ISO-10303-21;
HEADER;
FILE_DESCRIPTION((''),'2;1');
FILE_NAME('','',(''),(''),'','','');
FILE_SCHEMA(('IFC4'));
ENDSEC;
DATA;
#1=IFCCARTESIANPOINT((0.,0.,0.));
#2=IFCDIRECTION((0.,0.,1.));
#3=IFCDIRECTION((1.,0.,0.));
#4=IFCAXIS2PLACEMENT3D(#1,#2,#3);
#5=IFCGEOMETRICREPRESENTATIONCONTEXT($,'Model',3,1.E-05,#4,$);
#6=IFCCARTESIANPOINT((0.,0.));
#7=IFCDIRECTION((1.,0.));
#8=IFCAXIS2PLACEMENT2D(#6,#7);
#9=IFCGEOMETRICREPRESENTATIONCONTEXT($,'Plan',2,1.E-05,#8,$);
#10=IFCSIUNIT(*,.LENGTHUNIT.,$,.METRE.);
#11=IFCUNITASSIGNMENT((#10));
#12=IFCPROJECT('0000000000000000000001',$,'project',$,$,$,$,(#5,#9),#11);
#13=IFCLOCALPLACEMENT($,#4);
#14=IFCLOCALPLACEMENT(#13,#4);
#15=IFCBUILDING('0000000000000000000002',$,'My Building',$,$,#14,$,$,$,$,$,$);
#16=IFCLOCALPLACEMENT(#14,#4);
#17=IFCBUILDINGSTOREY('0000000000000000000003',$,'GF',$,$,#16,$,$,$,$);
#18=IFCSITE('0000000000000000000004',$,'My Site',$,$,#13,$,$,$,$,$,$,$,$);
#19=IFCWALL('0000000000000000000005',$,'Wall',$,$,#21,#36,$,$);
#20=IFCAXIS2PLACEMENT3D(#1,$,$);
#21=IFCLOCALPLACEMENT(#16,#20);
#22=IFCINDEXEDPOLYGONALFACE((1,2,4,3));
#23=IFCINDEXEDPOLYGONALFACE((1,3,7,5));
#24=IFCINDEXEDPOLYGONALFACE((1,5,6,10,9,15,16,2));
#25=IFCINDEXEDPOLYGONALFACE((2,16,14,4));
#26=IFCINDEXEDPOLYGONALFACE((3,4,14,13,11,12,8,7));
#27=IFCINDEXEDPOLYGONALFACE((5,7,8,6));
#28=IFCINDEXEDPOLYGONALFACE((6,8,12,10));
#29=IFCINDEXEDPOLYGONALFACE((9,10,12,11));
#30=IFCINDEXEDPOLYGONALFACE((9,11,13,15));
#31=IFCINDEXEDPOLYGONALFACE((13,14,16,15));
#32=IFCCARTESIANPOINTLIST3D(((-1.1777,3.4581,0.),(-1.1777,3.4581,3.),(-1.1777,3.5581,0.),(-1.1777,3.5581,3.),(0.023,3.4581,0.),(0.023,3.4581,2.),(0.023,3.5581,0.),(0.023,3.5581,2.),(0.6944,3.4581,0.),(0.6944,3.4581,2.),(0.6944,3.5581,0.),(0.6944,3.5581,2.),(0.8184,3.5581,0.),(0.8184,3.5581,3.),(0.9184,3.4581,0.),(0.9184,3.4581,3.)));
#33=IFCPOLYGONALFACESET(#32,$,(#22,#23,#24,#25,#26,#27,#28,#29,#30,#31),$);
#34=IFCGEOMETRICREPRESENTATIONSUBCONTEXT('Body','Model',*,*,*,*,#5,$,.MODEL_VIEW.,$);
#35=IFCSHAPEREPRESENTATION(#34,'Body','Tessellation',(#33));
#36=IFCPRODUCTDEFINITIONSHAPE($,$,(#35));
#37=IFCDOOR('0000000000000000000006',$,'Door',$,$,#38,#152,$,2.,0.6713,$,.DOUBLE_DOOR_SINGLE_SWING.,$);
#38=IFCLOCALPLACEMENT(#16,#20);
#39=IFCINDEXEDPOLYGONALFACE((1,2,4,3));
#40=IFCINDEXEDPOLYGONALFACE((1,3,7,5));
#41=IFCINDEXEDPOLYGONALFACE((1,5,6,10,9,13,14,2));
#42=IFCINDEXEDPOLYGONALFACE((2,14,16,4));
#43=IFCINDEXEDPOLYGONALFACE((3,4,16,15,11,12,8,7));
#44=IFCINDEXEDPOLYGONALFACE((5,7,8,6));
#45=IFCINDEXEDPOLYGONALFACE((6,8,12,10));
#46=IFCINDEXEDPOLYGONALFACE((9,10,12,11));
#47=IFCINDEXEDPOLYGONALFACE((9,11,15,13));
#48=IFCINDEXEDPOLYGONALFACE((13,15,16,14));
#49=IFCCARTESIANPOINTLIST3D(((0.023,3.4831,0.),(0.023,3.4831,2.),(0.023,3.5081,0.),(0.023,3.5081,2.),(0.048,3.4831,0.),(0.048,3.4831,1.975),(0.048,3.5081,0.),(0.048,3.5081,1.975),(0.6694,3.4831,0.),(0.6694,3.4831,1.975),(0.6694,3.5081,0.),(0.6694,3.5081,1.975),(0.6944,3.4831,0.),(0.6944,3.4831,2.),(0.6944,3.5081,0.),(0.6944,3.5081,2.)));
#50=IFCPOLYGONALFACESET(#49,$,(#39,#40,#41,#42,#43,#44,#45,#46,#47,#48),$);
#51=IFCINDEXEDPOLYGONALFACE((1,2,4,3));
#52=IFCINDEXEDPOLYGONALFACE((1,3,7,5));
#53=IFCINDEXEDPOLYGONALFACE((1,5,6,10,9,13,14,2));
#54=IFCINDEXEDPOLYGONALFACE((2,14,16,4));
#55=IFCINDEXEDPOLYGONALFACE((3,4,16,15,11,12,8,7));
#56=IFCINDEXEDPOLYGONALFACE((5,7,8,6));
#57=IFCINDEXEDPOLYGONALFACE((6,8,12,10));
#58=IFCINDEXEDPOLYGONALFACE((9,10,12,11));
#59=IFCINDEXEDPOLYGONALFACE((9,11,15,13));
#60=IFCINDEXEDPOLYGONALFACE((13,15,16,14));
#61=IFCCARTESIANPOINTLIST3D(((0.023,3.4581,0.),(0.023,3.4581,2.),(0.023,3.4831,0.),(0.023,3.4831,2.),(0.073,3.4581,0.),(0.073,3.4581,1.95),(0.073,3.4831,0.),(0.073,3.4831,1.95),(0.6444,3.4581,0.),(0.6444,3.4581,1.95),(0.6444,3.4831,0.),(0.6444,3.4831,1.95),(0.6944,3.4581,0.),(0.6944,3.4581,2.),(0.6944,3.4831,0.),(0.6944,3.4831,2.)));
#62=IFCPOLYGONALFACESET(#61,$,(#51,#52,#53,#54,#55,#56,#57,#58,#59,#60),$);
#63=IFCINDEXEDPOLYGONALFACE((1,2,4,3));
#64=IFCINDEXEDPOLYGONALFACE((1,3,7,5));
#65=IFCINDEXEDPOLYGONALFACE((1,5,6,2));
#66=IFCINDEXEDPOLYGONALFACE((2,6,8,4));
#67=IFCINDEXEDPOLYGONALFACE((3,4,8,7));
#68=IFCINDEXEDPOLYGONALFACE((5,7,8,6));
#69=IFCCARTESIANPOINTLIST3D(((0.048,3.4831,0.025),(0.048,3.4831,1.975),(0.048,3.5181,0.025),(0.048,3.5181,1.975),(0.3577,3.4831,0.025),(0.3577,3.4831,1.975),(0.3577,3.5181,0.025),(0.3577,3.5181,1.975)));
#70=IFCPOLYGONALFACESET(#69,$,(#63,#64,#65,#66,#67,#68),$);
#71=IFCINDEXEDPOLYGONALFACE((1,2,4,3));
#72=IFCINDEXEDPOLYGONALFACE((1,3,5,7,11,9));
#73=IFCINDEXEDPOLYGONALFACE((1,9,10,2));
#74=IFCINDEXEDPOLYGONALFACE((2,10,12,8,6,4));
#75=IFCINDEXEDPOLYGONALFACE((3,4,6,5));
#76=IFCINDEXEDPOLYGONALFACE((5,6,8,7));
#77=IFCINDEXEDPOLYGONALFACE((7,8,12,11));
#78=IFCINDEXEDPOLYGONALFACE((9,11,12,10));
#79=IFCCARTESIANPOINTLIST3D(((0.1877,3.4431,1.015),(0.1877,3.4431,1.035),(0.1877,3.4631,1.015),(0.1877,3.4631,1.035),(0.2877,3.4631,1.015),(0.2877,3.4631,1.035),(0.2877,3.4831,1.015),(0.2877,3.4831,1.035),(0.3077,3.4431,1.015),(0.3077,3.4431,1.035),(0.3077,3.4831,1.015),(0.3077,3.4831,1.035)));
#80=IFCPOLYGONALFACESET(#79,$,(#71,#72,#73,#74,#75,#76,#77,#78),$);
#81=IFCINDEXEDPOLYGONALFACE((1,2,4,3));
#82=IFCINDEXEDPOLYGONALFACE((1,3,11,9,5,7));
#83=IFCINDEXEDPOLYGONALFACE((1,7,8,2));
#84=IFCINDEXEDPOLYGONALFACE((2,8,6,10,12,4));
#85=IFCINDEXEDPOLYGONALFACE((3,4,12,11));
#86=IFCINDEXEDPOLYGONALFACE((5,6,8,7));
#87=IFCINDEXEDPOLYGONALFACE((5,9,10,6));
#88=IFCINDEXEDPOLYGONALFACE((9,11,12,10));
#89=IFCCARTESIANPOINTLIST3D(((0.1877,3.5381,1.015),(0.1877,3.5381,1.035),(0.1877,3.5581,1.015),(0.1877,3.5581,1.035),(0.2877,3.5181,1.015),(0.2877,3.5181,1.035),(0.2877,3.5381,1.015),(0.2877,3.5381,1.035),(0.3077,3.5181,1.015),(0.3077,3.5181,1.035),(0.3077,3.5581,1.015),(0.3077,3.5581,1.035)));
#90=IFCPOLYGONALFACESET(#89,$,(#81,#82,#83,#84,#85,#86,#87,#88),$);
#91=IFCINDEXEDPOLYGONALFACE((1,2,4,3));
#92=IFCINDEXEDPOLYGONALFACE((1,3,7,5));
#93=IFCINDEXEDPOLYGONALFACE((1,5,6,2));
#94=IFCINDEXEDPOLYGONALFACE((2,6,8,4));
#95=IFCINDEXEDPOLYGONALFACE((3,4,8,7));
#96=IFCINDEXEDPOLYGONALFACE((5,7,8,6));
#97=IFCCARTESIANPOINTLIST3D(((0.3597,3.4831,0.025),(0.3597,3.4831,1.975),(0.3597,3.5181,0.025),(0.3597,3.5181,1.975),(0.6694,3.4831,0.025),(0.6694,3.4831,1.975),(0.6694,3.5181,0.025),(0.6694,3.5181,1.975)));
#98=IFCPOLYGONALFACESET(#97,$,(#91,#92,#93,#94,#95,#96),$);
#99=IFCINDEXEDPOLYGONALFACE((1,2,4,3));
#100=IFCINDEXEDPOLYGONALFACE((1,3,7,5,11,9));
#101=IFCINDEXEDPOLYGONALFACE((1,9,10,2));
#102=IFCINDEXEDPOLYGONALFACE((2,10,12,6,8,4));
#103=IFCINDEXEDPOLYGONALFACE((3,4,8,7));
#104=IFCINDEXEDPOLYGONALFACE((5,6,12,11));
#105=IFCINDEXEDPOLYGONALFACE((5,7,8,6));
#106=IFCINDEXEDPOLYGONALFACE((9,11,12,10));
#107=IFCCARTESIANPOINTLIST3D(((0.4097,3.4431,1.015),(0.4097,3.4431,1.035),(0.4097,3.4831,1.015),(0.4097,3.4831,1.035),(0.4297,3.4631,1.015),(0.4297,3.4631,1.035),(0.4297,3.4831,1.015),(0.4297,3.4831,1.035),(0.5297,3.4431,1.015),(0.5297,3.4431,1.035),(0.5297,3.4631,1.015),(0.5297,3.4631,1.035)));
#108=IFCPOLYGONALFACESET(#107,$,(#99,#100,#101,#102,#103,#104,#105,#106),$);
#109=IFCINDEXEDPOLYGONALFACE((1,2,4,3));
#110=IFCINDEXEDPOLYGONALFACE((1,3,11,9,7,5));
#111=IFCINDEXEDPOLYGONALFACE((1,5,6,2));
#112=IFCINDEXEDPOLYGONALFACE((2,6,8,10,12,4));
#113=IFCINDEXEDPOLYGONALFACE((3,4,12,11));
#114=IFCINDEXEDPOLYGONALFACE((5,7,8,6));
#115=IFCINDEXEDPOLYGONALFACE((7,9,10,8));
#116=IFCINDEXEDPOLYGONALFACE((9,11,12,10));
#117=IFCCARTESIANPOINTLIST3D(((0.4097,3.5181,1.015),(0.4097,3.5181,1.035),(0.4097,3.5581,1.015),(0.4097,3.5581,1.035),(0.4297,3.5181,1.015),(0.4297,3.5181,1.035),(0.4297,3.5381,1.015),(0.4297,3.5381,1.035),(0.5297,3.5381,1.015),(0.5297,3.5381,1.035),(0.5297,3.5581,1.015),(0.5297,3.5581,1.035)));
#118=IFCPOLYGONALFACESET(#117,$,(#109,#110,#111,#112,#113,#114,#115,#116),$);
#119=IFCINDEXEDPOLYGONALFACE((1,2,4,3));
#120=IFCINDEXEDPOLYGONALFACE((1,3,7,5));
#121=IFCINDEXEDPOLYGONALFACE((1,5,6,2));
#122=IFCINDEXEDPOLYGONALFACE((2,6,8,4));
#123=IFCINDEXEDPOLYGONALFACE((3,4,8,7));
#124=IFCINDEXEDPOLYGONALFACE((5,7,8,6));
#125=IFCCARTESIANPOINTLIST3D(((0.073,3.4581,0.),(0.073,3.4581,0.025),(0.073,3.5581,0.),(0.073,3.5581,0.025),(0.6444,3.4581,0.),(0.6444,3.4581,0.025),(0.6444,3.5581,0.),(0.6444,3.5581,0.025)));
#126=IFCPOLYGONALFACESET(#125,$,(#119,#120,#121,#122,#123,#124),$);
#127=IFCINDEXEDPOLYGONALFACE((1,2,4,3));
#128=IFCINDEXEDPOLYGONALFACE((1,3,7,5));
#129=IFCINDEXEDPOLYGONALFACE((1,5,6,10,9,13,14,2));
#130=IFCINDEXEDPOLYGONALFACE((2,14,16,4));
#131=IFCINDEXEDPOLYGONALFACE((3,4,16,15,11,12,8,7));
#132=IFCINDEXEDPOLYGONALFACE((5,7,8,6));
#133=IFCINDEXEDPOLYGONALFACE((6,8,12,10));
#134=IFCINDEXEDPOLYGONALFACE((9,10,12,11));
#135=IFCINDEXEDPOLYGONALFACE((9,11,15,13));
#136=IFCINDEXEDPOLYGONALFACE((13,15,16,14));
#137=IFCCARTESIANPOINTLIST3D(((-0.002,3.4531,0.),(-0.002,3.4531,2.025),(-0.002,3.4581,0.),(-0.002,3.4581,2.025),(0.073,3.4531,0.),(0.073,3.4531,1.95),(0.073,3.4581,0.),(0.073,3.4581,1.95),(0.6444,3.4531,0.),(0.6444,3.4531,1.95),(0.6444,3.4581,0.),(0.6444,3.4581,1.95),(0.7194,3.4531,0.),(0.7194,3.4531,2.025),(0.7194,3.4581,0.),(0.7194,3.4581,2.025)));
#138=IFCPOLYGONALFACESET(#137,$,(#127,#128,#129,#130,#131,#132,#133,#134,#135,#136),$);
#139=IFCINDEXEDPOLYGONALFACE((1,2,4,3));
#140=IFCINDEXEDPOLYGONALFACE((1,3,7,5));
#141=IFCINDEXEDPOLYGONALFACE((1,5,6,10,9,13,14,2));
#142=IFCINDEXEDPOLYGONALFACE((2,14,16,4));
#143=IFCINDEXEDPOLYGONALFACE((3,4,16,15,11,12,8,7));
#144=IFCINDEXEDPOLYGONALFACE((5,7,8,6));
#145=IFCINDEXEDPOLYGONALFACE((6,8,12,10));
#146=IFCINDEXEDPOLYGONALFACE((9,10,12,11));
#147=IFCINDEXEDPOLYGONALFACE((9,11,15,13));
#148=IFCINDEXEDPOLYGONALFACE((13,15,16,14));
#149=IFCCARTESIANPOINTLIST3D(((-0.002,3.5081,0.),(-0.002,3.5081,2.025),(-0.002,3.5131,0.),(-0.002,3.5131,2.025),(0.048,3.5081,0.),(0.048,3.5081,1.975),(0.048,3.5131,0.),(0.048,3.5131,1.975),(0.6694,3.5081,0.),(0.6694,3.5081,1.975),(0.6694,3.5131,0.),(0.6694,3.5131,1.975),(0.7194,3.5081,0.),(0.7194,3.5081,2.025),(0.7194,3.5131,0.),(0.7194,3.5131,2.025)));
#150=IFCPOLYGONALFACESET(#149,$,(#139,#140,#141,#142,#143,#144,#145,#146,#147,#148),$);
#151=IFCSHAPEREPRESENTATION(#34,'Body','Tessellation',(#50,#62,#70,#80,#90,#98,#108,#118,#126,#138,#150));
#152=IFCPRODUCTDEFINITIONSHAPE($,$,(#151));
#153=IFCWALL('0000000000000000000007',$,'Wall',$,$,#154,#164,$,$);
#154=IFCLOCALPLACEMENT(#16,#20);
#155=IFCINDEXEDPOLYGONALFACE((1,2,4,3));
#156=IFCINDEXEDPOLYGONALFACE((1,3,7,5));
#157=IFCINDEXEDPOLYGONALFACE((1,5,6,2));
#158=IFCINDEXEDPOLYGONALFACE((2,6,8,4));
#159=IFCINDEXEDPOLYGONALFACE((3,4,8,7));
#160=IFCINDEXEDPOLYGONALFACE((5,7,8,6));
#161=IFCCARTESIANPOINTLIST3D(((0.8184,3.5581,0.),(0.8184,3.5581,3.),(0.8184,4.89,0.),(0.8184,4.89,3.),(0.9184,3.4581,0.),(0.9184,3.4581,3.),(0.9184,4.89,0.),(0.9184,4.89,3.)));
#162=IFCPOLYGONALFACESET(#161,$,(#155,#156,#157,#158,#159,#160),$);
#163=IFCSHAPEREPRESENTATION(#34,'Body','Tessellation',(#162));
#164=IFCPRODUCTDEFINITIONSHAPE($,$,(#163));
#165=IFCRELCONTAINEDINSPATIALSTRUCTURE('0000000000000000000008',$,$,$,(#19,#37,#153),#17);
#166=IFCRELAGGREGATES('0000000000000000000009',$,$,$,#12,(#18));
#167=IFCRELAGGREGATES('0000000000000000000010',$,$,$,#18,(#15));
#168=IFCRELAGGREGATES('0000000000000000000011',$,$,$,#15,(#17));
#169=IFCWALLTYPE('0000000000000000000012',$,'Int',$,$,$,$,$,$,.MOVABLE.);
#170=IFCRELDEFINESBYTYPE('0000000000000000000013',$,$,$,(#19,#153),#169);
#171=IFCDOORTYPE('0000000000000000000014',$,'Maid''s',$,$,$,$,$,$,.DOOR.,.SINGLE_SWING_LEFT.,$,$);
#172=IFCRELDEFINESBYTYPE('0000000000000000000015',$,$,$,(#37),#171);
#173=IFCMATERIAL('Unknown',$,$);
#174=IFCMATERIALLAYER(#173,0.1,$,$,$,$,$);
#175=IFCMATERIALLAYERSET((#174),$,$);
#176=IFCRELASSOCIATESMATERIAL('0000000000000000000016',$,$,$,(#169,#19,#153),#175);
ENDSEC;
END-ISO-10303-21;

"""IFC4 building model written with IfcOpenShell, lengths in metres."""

from ifc_helpers import new_model, entity, si_unit, frame, origin_with_axes, origin_2d_with_axis, place, context, subcontext, project, spatial, line, indexed_curve, outline, extrude, shape, source, transform, mapped, material, layer, layer_set, layer_usage, type_object, type_shapes, element, fill, save


model = new_model("IFC4")

# Units and contexts
model_context = context("Model", 3, precision=1e-05, world=origin_with_axes())
plan_context = context("Plan", 2, precision=1e-05, world=origin_2d_with_axis())
body_context_1 = subcontext(model_context, "Body", "Model", "MODEL_VIEW")
body_context_2 = subcontext(plan_context, "Body", "Plan", "PLAN_VIEW")
ifc_project = project(units=[si_unit("LENGTHUNIT", "METRE")], contexts=[model_context, plan_context])

# Site, building, storey
site_placement = place(None, origin_with_axes())
site = spatial("IfcSite", under=ifc_project, at=site_placement, Name="My Site")
building_placement = place(site_placement, origin_with_axes())
building = spatial("IfcBuilding", under=site, at=building_placement, Name="My Building")
storey_placement = place(building_placement, origin_with_axes())
storey = spatial("IfcBuildingStorey", under=building, at=storey_placement, Name="GF")

# Shared definitions
ifc_material = material(Name="Unknown")

# Shared definitions
ifc_layer_1 = layer(ifc_material, 0.1)
ifc_layer_set_1 = layer_set([ifc_layer_1])
wall_type_1 = type_object("IfcWallType", Name="Int", PredefinedType="MOVABLE", material=ifc_layer_set_1)

# Wall, opening, door
ifc_layer_usage_1 = layer_usage(ifc_layer_set_1, "AXIS2", "POSITIVE", 0.0)
wall_1_placement = place(storey_placement, frame((-1.1777, 3.4581, 0.0), z_axis=(0.0, 0.0, 1.0), x_axis=(1.0, 0.0, 0.0)))
wall_1 = element("IfcWall", 1, at=wall_1_placement, inside=storey, type_object=wall_type_1, material=ifc_layer_usage_1, Name="Wall", context=body_context_1, shape_type="SweptSolid", body=[
    extrude(outline(indexed_curve([(0.0, 0.0), (0.0, 0.1), (1.9961, 0.1), (2.0961, 0.0)], segments=[line(1, 2, 3, 4, 1)])), origin_with_axes(), (0.0, 0.0, 1.0), 3.0),
])
shared_shape_1 = source(origin_with_axes(), body_context_1, "Body", "SweptSolid", [
    extrude(outline(indexed_curve([(0.0, 0.0), (0.6713, 0.0), (0.6713, 2.0), (0.0, 2.0)], segments=[line(1, 2, 3, 4, 1)])), frame((0.0, -0.6, 0.0), z_axis=(0.0, -1.0, 0.0), x_axis=(1.0, 0.0, 0.0)), (0.0, 0.0, -1.0), 1.2),
])
opening_1_placement = place(wall_1_placement, frame((1.2007, 0.0, 0.0), z_axis=(0.0, 0.0, 1.0), x_axis=(1.0, 0.0, 0.0)))
opening_1 = element("IfcOpeningElement", 2, at=opening_1_placement, cuts=wall_1, PredefinedType="OPENING", context=body_context_1, shape_type="MappedRepresentation", body=[
    mapped(shared_shape_1, transform((0.0, 0.0, 0.0), x_axis=(1.0, 0.0, 0.0), y_axis=(0.0, 1.0, 0.0), z_axis=(0.0, 0.0, 1.0), scale=1.0)),
])
door_type_1 = type_object("IfcDoorType", Name="Maid's", OperationType="SINGLE_SWING_LEFT", PredefinedType="DOOR")
shared_shape_2 = source(origin_with_axes(), body_context_1, "Body", "SweptSolid", [
    extrude(outline(indexed_curve([(0.0, 0.0), (0.0, 2.0), (0.6713, 2.0), (0.6713, 0.0), (0.6463, 0.0), (0.6463, 1.975), (0.025, 1.975), (0.025, 0.0)], segments=[line(1, 2, 3, 4, 5, 6, 7, 8, 1)])), frame((0.0, 0.025, 0.0), z_axis=(0.0, -1.0, 0.0), x_axis=(1.0, 0.0, 0.0)), (0.0, 0.0, -1.0), 0.025),
    extrude(outline(indexed_curve([(0.0, 0.0), (0.0, 2.0), (0.6713, 2.0), (0.6713, 0.0), (0.6213, 0.0), (0.6213, 1.95), (0.05, 1.95), (0.05, 0.0)], segments=[line(1, 2, 3, 4, 5, 6, 7, 8, 1)])), frame((0.0, 0.0, 0.0), z_axis=(0.0, -1.0, 0.0), x_axis=(1.0, 0.0, 0.0)), (0.0, 0.0, -1.0), 0.025),
    extrude(outline(indexed_curve([(0.0, 0.0), (0.3097, 0.0), (0.3097, 0.035), (0.0, 0.035)], segments=[line(1, 2, 3, 4, 1)])), frame((0.025, 0.025, 0.025), z_axis=(0.0, 0.0, 1.0), x_axis=(1.0, 0.0, 0.0)), (0.0, 0.0, 1.0), 1.95),
    extrude(outline(indexed_curve([(0.0, 0.0), (0.0, -0.04), (-0.12, -0.04), (-0.12, -0.02), (-0.02, -0.02), (-0.02, 0.0)], segments=[line(1, 2, 3, 4, 5, 6, 1)])), frame((0.2847, 0.025, 1.015), z_axis=(0.0, 0.0, 1.0), x_axis=(1.0, 0.0, 0.0)), (0.0, 0.0, 1.0), 0.02),
    extrude(outline(indexed_curve([(0.0, 0.0), (0.0, 0.04), (-0.12, 0.04), (-0.12, 0.02), (-0.02, 0.02), (-0.02, 0.0)], segments=[line(1, 2, 3, 4, 5, 6, 1)])), frame((0.2847, 0.06, 1.015), z_axis=(0.0, 0.0, 1.0), x_axis=(1.0, 0.0, 0.0)), (0.0, 0.0, 1.0), 0.02),
    extrude(outline(indexed_curve([(0.0, 0.0), (-0.3097, 0.0), (-0.3097, 0.035), (0.0, 0.035)], segments=[line(1, 2, 3, 4, 1)])), frame((0.6463, 0.025, 0.025), z_axis=(0.0, 0.0, 1.0), x_axis=(1.0, 0.0, 0.0)), (0.0, 0.0, 1.0), 1.95),
    extrude(outline(indexed_curve([(0.0, 0.0), (0.0, -0.04), (0.12, -0.04), (0.12, -0.02), (0.02, -0.02), (0.02, 0.0)], segments=[line(1, 2, 3, 4, 5, 6, 1)])), frame((0.3867, 0.025, 1.015), z_axis=(0.0, 0.0, 1.0), x_axis=(1.0, 0.0, 0.0)), (0.0, 0.0, 1.0), 0.02),
    extrude(outline(indexed_curve([(0.0, 0.0), (0.0, 0.04), (0.12, 0.04), (0.12, 0.02), (0.02, 0.02), (0.02, 0.0)], segments=[line(1, 2, 3, 4, 5, 6, 1)])), frame((0.3867, 0.06, 1.015), z_axis=(0.0, 0.0, 1.0), x_axis=(1.0, 0.0, 0.0)), (0.0, 0.0, 1.0), 0.02),
    extrude(outline(indexed_curve([(0.0, 0.0), (0.5713, 0.0), (0.5713, 0.1), (0.0, 0.1)], segments=[line(1, 2, 3, 4, 1)])), frame((0.05, 0.0, 0.0), z_axis=(0.0, 0.0, 1.0), x_axis=(1.0, 0.0, 0.0)), (0.0, 0.0, 1.0), 0.025),
    extrude(outline(indexed_curve([(0.0, 0.0), (0.0, 2.025), (0.7213, 2.025), (0.7213, 0.0), (0.6463, 0.0), (0.6463, 1.95), (0.075, 1.95), (0.075, 0.0)], segments=[line(1, 2, 3, 4, 5, 6, 7, 8, 1)])), frame((-0.025, -0.005, 0.0), z_axis=(0.0, -1.0, 0.0), x_axis=(1.0, 0.0, 0.0)), (0.0, 0.0, -1.0), 0.005),
    extrude(outline(indexed_curve([(0.0, 0.0), (0.0, 2.025), (0.7213, 2.025), (0.7213, 0.0), (0.6713, 0.0), (0.6713, 1.975), (0.05, 1.975), (0.05, 0.0)], segments=[line(1, 2, 3, 4, 5, 6, 7, 8, 1)])), frame((-0.025, 0.05, 0.0), z_axis=(0.0, -1.0, 0.0), x_axis=(1.0, 0.0, 0.0)), (0.0, 0.0, -1.0), 0.005),
])
shared_shape_3 = source(origin_with_axes(), body_context_2, "Body", "Curve2D", [
    entity("IfcIndexedPolyCurve", entity("IfcCartesianPointList2D", [[0.0, 0.0], [0.0, 0.05], [0.025, 0.05], [0.025, 0.025], [0.05, 0.025], [0.05, 0.0]]), [entity("IfcLineIndex", [1, 2, 3, 4, 5, 6, 1])]),
    entity("IfcIndexedPolyCurve", entity("IfcCartesianPointList2D", [[0.6713, 0.0], [0.6713, 0.05], [0.6463, 0.05], [0.6463, 0.025], [0.6213, 0.025], [0.6213, 0.0]]), [entity("IfcLineIndex", [1, 2, 3, 4, 5, 6, 1])]),
    entity("IfcTrimmedCurve", entity("IfcEllipse", entity("IfcAxis2Placement2D", entity("IfcCartesianPoint", [0.06, 0.05]), entity("IfcDirection", [1.0, 0.0])), 0.2757, 0.3107), [entity("IfcCartesianPoint", [0.3357, 0.05])], [entity("IfcCartesianPoint", [0.06, 0.3607])], True, "CARTESIAN"),
    entity("IfcIndexedPolyCurve", entity("IfcCartesianPointList2D", [[0.025, 0.05], [0.06, 0.05], [0.06, 0.3607], [0.025, 0.3607]]), [entity("IfcLineIndex", [1, 2, 3, 4, 1])]),
    entity("IfcTrimmedCurve", entity("IfcEllipse", entity("IfcAxis2Placement2D", entity("IfcCartesianPoint", [0.6113, 0.05]), entity("IfcDirection", [1.0, 0.0])), 0.2757, 0.3107), [entity("IfcCartesianPoint", [0.6113, 0.3607])], [entity("IfcCartesianPoint", [0.3357, 0.05])], True, "CARTESIAN"),
    entity("IfcIndexedPolyCurve", entity("IfcCartesianPointList2D", [[0.6463, 0.05], [0.6113, 0.05], [0.6113, 0.3607], [0.6463, 0.3607]]), [entity("IfcLineIndex", [1, 2, 3, 4, 1])]),
])
type_shapes(door_type_1, [shared_shape_2, shared_shape_3])
door_1_placement = place(opening_1_placement, origin_with_axes())
door_1 = element("IfcDoor", 3, at=door_1_placement, inside=storey, type_object=door_type_1, Name="Door", OperationType="DOUBLE_DOOR_SINGLE_SWING", OverallHeight=2.0, OverallWidth=0.6713, shapes=[
    shape(body_context_1, "Body", "MappedRepresentation", [mapped(shared_shape_2, transform((0.0, 0.0, 0.0), x_axis=(1.0, 0.0, 0.0), y_axis=(0.0, 1.0, 0.0), z_axis=(0.0, 0.0, 1.0), scale=1.0))]),
    shape(body_context_2, "Body", "MappedRepresentation", [mapped(shared_shape_3, transform((0.0, 0.0, 0.0), x_axis=(1.0, 0.0, 0.0), y_axis=(0.0, 1.0, 0.0), z_axis=(0.0, 0.0, 1.0), scale=1.0))]),
])
fill(opening_1, door_1)

# Wall
ifc_layer_usage_2 = layer_usage(ifc_layer_set_1, "AXIS2", "POSITIVE", 0.0)
wall_2_placement = place(storey_placement, frame((0.9184, 3.4581, 0.0), z_axis=(0.0, 0.0, 1.0), x_axis=(0.0, 1.0, 0.0)))
element("IfcWall", 4, at=wall_2_placement, inside=storey, type_object=wall_type_1, material=ifc_layer_usage_2, Name="Wall", context=body_context_1, shape_type="SweptSolid", body=[
    extrude(outline(indexed_curve([(0.0, 0.0), (0.1, 0.1), (1.4319, 0.1), (1.4319, 0.0)], segments=[line(1, 2, 3, 4, 1)])), origin_with_axes(), (0.0, 0.0, 1.0), 3.0),
])

save(model, "model.ifc")
